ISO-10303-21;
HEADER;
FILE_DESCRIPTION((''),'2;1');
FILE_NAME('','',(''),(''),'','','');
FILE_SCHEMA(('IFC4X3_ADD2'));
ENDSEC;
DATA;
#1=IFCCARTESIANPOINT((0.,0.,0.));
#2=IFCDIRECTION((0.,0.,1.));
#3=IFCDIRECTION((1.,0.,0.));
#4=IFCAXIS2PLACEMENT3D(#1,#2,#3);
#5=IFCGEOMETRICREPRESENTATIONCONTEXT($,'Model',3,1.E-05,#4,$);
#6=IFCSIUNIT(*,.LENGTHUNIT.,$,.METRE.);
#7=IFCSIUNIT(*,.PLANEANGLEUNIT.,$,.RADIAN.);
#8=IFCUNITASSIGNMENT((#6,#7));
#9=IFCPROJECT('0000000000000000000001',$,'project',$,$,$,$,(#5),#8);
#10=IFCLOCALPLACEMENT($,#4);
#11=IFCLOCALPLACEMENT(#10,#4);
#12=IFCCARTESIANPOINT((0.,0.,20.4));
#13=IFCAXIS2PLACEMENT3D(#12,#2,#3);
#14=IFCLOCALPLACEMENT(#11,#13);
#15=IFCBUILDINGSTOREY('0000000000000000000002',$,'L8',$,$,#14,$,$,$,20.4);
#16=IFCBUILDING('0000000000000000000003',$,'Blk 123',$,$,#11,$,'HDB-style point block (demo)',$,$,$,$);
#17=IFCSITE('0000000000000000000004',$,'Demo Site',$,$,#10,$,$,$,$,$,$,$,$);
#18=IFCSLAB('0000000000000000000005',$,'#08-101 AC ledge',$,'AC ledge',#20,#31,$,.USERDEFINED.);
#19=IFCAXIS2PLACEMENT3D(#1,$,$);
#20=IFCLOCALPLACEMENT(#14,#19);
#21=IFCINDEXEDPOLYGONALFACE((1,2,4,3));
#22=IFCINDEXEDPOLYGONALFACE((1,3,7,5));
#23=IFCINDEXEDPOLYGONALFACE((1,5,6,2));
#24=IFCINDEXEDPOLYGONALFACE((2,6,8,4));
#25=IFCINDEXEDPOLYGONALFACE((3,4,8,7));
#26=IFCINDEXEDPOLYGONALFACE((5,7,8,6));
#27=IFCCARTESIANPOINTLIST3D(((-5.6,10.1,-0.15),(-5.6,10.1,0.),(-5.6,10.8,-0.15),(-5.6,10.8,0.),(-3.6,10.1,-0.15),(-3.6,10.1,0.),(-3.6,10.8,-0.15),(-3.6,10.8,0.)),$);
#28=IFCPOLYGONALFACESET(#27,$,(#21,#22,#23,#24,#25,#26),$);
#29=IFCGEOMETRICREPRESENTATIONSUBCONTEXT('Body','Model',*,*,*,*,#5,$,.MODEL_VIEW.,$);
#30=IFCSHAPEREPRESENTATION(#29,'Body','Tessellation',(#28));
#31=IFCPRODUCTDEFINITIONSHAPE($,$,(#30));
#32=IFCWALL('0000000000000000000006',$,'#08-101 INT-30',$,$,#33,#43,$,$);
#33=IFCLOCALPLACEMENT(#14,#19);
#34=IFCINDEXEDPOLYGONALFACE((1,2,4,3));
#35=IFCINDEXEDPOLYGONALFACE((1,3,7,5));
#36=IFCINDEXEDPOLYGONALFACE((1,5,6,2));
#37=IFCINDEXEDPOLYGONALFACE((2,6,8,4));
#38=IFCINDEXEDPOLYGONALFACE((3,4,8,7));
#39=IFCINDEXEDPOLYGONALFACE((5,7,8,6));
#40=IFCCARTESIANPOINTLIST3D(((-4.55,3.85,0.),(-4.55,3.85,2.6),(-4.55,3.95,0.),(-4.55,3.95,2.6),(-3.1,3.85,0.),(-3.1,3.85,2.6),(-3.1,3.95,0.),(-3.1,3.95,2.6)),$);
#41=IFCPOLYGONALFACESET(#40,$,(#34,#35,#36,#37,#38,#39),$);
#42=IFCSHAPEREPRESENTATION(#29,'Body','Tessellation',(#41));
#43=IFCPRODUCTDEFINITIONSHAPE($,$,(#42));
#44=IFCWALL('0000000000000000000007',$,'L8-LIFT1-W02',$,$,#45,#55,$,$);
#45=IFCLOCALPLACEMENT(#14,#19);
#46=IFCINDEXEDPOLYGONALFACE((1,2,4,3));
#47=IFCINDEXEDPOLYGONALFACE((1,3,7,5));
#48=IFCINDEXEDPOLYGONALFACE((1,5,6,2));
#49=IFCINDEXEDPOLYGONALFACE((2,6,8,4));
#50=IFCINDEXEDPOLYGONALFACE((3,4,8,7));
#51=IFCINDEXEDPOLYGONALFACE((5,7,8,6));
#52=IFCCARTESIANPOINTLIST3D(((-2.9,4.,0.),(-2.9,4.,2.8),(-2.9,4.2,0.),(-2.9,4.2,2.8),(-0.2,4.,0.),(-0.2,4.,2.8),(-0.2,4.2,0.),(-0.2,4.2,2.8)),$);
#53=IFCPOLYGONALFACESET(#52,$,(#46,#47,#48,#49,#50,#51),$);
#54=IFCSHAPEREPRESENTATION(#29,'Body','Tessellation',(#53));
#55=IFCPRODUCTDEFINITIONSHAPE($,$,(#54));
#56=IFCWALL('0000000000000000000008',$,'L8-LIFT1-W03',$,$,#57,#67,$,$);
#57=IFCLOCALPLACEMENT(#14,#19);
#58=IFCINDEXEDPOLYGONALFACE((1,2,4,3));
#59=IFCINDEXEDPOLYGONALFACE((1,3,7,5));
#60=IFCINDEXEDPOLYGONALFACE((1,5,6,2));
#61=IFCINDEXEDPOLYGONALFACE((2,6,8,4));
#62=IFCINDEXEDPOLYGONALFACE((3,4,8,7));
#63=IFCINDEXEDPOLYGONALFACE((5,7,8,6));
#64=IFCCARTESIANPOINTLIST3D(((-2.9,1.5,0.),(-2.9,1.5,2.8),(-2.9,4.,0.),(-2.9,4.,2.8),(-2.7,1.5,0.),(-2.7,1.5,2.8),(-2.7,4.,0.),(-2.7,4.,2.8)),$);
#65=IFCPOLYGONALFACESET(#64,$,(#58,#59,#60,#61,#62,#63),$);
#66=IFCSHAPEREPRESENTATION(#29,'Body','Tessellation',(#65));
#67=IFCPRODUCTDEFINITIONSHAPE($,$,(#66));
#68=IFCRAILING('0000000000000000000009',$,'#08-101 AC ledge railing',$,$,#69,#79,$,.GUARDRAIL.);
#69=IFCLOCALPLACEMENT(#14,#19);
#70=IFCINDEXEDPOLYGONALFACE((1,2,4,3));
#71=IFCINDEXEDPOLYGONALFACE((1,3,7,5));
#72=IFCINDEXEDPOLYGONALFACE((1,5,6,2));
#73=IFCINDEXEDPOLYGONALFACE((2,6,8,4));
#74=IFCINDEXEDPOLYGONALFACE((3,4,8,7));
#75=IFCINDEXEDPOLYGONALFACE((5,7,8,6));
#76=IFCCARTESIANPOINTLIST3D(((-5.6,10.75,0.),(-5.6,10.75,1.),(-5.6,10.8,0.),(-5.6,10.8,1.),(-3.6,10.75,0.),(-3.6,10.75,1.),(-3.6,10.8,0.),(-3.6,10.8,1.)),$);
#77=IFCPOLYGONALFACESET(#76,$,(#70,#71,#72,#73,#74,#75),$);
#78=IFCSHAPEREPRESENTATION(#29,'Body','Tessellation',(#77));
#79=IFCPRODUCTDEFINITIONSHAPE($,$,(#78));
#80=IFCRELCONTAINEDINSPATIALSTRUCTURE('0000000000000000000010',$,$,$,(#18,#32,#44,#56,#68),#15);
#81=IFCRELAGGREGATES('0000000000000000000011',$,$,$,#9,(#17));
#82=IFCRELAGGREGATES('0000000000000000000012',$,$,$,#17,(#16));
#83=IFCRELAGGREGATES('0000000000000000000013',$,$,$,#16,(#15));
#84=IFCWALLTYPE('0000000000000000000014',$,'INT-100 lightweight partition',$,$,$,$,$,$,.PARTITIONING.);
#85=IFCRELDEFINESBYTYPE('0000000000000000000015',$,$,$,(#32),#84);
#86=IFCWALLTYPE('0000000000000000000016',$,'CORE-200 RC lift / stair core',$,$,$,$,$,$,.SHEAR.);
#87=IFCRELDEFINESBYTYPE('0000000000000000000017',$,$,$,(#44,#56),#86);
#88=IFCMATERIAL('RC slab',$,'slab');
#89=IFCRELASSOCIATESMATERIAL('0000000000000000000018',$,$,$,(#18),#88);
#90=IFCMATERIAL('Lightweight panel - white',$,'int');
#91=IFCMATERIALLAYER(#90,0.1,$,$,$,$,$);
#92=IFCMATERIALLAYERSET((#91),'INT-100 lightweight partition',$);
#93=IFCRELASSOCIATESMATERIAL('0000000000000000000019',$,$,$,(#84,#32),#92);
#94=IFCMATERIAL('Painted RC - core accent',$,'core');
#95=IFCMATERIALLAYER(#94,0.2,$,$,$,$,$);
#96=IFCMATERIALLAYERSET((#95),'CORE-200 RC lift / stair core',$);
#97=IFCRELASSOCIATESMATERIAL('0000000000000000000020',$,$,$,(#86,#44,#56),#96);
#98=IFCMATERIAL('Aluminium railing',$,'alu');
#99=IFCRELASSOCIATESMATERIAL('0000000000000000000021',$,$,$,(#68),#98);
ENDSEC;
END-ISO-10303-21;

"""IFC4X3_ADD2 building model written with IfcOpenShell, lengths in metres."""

from ifc_helpers import new_model, si_unit, frame, origin, origin_with_axes, place, context, subcontext, project, spatial, polyline, indexed_curve, outline, extrude, material, layer, layer_set, layer_usage, type_object, element, save


model = new_model("IFC4X3_ADD2")

# Units and contexts
model_context = context("Model", 3, precision=1e-05, world=origin_with_axes())
body_context = subcontext(model_context, "Body", "Model", "MODEL_VIEW")
ifc_project = project(units=[si_unit("LENGTHUNIT", "METRE"), si_unit("PLANEANGLEUNIT", "RADIAN")], contexts=[model_context])

# Site, building, storey
site_placement = place(None, origin_with_axes())
site = spatial("IfcSite", under=ifc_project, at=site_placement, Name="Demo Site")
building_placement = place(site_placement, origin_with_axes())
building = spatial("IfcBuilding", under=site, at=building_placement, Name="Blk 123", LongName="HDB-style point block (demo)")
storey_placement = place(building_placement, frame((0.0, 0.0, 20.4), z_axis=(0.0, 0.0, 1.0), x_axis=(1.0, 0.0, 0.0)))
storey = spatial("IfcBuildingStorey", under=building, at=storey_placement, Name="L8", Elevation=20.4)

# Slab
ifc_material_1 = material(Name="RC slab", Category="slab")
slab_placement = place(storey_placement, frame((-4.6, 10.45, -0.15), z_axis=(0.0, 0.0, 1.0), x_axis=(1.0, 0.0, 0.0)))
element("IfcSlab", 1, at=slab_placement, inside=storey, material=ifc_material_1, Name="#08-101 AC ledge", ObjectType="AC ledge", PredefinedType="USERDEFINED", context=body_context, shape_type="SweptSolid", body=[
    extrude(outline(polyline([(-1.0, -0.35), (1.0, -0.35), (1.0, 0.35), (-1.0, 0.35), (-1.0, -0.35)])), origin(), (0.0, 0.0, 1.0), 0.15),
])

# Shared definitions
ifc_material_2 = material(Name="Lightweight panel - white", Category="int")
ifc_layer_1 = layer(ifc_material_2, 0.1)
ifc_layer_set_1 = layer_set([ifc_layer_1], Name="INT-100 lightweight partition")
ifc_layer_usage_1 = layer_usage(ifc_layer_set_1, "AXIS2", "POSITIVE", -0.05)
wall_type_1 = type_object("IfcWallType", Name="INT-100 lightweight partition", PredefinedType="PARTITIONING", material=ifc_layer_set_1)

# Wall
wall_1_placement = place(storey_placement, frame((-3.1, 3.9, 0.0), z_axis=(0.0, 0.0, 1.0), x_axis=(-1.0, 0.0, 0.0)))
element("IfcWall", 2, at=wall_1_placement, inside=storey, type_object=wall_type_1, material=ifc_layer_usage_1, Name="#08-101 INT-30", context=body_context, shape_type="SweptSolid", body=[
    extrude(outline(indexed_curve([(0.0, 0.0), (0.0, 0.1), (1.45, 0.1), (1.45, 0.0), (0.0, 0.0)], self_intersect=False)), frame((0.0, -0.05, 0.0), z_axis=(0.0, 0.0, 1.0), x_axis=(1.0, 0.0, 0.0)), (0.0, 0.0, 1.0), 2.6),
])

# Walls
ifc_material_3 = material(Name="Painted RC - core accent", Category="core")
ifc_layer_2 = layer(ifc_material_3, 0.2)
ifc_layer_set_2 = layer_set([ifc_layer_2], Name="CORE-200 RC lift / stair core")
ifc_layer_usage_2 = layer_usage(ifc_layer_set_2, "AXIS2", "POSITIVE", 0.0)
wall_type_2 = type_object("IfcWallType", Name="CORE-200 RC lift / stair core", PredefinedType="SHEAR", material=ifc_layer_set_2)
wall_2_placement = place(storey_placement, frame((-0.2, 4.2, 0.0), z_axis=(0.0, 0.0, 1.0), x_axis=(-1.0, 0.0, 0.0)))
element("IfcWall", 3, at=wall_2_placement, inside=storey, type_object=wall_type_2, material=ifc_layer_usage_2, Name="L8-LIFT1-W02", context=body_context, shape_type="SweptSolid", body=[
    extrude(outline(indexed_curve([(0.0, 0.0), (0.0, 0.2), (2.7, 0.2), (2.7, 0.0), (0.0, 0.0)], self_intersect=False)), origin_with_axes(), (0.0, 0.0, 1.0), 2.8),
])
wall_3_placement = place(storey_placement, frame((-2.9, 4.0, 0.0), z_axis=(0.0, 0.0, 1.0), x_axis=(0.0, -1.0, 0.0)))
element("IfcWall", 4, at=wall_3_placement, inside=storey, type_object=wall_type_2, material=ifc_layer_usage_2, Name="L8-LIFT1-W03", context=body_context, shape_type="SweptSolid", body=[
    extrude(outline(indexed_curve([(0.0, 0.0), (0.0, 0.2), (2.5, 0.2), (2.5, 0.0), (0.0, 0.0)], self_intersect=False)), origin_with_axes(), (0.0, 0.0, 1.0), 2.8),
])

# Railing
ifc_material_4 = material(Name="Aluminium railing", Category="alu")
railing_placement = place(storey_placement, frame((-4.6, 10.775, 0.0), z_axis=(0.0, 0.0, 1.0), x_axis=(1.0, 0.0, 0.0)))
element("IfcRailing", 5, at=railing_placement, inside=storey, material=ifc_material_4, Name="#08-101 AC ledge railing", PredefinedType="GUARDRAIL", context=body_context, shape_type="SweptSolid", body=[
    extrude(outline(polyline([(-1.0, -0.025), (1.0, -0.025), (1.0, 0.025), (-1.0, 0.025), (-1.0, -0.025)])), origin(), (0.0, 0.0, 1.0), 1.0),
])

save(model, "model.ifc")
